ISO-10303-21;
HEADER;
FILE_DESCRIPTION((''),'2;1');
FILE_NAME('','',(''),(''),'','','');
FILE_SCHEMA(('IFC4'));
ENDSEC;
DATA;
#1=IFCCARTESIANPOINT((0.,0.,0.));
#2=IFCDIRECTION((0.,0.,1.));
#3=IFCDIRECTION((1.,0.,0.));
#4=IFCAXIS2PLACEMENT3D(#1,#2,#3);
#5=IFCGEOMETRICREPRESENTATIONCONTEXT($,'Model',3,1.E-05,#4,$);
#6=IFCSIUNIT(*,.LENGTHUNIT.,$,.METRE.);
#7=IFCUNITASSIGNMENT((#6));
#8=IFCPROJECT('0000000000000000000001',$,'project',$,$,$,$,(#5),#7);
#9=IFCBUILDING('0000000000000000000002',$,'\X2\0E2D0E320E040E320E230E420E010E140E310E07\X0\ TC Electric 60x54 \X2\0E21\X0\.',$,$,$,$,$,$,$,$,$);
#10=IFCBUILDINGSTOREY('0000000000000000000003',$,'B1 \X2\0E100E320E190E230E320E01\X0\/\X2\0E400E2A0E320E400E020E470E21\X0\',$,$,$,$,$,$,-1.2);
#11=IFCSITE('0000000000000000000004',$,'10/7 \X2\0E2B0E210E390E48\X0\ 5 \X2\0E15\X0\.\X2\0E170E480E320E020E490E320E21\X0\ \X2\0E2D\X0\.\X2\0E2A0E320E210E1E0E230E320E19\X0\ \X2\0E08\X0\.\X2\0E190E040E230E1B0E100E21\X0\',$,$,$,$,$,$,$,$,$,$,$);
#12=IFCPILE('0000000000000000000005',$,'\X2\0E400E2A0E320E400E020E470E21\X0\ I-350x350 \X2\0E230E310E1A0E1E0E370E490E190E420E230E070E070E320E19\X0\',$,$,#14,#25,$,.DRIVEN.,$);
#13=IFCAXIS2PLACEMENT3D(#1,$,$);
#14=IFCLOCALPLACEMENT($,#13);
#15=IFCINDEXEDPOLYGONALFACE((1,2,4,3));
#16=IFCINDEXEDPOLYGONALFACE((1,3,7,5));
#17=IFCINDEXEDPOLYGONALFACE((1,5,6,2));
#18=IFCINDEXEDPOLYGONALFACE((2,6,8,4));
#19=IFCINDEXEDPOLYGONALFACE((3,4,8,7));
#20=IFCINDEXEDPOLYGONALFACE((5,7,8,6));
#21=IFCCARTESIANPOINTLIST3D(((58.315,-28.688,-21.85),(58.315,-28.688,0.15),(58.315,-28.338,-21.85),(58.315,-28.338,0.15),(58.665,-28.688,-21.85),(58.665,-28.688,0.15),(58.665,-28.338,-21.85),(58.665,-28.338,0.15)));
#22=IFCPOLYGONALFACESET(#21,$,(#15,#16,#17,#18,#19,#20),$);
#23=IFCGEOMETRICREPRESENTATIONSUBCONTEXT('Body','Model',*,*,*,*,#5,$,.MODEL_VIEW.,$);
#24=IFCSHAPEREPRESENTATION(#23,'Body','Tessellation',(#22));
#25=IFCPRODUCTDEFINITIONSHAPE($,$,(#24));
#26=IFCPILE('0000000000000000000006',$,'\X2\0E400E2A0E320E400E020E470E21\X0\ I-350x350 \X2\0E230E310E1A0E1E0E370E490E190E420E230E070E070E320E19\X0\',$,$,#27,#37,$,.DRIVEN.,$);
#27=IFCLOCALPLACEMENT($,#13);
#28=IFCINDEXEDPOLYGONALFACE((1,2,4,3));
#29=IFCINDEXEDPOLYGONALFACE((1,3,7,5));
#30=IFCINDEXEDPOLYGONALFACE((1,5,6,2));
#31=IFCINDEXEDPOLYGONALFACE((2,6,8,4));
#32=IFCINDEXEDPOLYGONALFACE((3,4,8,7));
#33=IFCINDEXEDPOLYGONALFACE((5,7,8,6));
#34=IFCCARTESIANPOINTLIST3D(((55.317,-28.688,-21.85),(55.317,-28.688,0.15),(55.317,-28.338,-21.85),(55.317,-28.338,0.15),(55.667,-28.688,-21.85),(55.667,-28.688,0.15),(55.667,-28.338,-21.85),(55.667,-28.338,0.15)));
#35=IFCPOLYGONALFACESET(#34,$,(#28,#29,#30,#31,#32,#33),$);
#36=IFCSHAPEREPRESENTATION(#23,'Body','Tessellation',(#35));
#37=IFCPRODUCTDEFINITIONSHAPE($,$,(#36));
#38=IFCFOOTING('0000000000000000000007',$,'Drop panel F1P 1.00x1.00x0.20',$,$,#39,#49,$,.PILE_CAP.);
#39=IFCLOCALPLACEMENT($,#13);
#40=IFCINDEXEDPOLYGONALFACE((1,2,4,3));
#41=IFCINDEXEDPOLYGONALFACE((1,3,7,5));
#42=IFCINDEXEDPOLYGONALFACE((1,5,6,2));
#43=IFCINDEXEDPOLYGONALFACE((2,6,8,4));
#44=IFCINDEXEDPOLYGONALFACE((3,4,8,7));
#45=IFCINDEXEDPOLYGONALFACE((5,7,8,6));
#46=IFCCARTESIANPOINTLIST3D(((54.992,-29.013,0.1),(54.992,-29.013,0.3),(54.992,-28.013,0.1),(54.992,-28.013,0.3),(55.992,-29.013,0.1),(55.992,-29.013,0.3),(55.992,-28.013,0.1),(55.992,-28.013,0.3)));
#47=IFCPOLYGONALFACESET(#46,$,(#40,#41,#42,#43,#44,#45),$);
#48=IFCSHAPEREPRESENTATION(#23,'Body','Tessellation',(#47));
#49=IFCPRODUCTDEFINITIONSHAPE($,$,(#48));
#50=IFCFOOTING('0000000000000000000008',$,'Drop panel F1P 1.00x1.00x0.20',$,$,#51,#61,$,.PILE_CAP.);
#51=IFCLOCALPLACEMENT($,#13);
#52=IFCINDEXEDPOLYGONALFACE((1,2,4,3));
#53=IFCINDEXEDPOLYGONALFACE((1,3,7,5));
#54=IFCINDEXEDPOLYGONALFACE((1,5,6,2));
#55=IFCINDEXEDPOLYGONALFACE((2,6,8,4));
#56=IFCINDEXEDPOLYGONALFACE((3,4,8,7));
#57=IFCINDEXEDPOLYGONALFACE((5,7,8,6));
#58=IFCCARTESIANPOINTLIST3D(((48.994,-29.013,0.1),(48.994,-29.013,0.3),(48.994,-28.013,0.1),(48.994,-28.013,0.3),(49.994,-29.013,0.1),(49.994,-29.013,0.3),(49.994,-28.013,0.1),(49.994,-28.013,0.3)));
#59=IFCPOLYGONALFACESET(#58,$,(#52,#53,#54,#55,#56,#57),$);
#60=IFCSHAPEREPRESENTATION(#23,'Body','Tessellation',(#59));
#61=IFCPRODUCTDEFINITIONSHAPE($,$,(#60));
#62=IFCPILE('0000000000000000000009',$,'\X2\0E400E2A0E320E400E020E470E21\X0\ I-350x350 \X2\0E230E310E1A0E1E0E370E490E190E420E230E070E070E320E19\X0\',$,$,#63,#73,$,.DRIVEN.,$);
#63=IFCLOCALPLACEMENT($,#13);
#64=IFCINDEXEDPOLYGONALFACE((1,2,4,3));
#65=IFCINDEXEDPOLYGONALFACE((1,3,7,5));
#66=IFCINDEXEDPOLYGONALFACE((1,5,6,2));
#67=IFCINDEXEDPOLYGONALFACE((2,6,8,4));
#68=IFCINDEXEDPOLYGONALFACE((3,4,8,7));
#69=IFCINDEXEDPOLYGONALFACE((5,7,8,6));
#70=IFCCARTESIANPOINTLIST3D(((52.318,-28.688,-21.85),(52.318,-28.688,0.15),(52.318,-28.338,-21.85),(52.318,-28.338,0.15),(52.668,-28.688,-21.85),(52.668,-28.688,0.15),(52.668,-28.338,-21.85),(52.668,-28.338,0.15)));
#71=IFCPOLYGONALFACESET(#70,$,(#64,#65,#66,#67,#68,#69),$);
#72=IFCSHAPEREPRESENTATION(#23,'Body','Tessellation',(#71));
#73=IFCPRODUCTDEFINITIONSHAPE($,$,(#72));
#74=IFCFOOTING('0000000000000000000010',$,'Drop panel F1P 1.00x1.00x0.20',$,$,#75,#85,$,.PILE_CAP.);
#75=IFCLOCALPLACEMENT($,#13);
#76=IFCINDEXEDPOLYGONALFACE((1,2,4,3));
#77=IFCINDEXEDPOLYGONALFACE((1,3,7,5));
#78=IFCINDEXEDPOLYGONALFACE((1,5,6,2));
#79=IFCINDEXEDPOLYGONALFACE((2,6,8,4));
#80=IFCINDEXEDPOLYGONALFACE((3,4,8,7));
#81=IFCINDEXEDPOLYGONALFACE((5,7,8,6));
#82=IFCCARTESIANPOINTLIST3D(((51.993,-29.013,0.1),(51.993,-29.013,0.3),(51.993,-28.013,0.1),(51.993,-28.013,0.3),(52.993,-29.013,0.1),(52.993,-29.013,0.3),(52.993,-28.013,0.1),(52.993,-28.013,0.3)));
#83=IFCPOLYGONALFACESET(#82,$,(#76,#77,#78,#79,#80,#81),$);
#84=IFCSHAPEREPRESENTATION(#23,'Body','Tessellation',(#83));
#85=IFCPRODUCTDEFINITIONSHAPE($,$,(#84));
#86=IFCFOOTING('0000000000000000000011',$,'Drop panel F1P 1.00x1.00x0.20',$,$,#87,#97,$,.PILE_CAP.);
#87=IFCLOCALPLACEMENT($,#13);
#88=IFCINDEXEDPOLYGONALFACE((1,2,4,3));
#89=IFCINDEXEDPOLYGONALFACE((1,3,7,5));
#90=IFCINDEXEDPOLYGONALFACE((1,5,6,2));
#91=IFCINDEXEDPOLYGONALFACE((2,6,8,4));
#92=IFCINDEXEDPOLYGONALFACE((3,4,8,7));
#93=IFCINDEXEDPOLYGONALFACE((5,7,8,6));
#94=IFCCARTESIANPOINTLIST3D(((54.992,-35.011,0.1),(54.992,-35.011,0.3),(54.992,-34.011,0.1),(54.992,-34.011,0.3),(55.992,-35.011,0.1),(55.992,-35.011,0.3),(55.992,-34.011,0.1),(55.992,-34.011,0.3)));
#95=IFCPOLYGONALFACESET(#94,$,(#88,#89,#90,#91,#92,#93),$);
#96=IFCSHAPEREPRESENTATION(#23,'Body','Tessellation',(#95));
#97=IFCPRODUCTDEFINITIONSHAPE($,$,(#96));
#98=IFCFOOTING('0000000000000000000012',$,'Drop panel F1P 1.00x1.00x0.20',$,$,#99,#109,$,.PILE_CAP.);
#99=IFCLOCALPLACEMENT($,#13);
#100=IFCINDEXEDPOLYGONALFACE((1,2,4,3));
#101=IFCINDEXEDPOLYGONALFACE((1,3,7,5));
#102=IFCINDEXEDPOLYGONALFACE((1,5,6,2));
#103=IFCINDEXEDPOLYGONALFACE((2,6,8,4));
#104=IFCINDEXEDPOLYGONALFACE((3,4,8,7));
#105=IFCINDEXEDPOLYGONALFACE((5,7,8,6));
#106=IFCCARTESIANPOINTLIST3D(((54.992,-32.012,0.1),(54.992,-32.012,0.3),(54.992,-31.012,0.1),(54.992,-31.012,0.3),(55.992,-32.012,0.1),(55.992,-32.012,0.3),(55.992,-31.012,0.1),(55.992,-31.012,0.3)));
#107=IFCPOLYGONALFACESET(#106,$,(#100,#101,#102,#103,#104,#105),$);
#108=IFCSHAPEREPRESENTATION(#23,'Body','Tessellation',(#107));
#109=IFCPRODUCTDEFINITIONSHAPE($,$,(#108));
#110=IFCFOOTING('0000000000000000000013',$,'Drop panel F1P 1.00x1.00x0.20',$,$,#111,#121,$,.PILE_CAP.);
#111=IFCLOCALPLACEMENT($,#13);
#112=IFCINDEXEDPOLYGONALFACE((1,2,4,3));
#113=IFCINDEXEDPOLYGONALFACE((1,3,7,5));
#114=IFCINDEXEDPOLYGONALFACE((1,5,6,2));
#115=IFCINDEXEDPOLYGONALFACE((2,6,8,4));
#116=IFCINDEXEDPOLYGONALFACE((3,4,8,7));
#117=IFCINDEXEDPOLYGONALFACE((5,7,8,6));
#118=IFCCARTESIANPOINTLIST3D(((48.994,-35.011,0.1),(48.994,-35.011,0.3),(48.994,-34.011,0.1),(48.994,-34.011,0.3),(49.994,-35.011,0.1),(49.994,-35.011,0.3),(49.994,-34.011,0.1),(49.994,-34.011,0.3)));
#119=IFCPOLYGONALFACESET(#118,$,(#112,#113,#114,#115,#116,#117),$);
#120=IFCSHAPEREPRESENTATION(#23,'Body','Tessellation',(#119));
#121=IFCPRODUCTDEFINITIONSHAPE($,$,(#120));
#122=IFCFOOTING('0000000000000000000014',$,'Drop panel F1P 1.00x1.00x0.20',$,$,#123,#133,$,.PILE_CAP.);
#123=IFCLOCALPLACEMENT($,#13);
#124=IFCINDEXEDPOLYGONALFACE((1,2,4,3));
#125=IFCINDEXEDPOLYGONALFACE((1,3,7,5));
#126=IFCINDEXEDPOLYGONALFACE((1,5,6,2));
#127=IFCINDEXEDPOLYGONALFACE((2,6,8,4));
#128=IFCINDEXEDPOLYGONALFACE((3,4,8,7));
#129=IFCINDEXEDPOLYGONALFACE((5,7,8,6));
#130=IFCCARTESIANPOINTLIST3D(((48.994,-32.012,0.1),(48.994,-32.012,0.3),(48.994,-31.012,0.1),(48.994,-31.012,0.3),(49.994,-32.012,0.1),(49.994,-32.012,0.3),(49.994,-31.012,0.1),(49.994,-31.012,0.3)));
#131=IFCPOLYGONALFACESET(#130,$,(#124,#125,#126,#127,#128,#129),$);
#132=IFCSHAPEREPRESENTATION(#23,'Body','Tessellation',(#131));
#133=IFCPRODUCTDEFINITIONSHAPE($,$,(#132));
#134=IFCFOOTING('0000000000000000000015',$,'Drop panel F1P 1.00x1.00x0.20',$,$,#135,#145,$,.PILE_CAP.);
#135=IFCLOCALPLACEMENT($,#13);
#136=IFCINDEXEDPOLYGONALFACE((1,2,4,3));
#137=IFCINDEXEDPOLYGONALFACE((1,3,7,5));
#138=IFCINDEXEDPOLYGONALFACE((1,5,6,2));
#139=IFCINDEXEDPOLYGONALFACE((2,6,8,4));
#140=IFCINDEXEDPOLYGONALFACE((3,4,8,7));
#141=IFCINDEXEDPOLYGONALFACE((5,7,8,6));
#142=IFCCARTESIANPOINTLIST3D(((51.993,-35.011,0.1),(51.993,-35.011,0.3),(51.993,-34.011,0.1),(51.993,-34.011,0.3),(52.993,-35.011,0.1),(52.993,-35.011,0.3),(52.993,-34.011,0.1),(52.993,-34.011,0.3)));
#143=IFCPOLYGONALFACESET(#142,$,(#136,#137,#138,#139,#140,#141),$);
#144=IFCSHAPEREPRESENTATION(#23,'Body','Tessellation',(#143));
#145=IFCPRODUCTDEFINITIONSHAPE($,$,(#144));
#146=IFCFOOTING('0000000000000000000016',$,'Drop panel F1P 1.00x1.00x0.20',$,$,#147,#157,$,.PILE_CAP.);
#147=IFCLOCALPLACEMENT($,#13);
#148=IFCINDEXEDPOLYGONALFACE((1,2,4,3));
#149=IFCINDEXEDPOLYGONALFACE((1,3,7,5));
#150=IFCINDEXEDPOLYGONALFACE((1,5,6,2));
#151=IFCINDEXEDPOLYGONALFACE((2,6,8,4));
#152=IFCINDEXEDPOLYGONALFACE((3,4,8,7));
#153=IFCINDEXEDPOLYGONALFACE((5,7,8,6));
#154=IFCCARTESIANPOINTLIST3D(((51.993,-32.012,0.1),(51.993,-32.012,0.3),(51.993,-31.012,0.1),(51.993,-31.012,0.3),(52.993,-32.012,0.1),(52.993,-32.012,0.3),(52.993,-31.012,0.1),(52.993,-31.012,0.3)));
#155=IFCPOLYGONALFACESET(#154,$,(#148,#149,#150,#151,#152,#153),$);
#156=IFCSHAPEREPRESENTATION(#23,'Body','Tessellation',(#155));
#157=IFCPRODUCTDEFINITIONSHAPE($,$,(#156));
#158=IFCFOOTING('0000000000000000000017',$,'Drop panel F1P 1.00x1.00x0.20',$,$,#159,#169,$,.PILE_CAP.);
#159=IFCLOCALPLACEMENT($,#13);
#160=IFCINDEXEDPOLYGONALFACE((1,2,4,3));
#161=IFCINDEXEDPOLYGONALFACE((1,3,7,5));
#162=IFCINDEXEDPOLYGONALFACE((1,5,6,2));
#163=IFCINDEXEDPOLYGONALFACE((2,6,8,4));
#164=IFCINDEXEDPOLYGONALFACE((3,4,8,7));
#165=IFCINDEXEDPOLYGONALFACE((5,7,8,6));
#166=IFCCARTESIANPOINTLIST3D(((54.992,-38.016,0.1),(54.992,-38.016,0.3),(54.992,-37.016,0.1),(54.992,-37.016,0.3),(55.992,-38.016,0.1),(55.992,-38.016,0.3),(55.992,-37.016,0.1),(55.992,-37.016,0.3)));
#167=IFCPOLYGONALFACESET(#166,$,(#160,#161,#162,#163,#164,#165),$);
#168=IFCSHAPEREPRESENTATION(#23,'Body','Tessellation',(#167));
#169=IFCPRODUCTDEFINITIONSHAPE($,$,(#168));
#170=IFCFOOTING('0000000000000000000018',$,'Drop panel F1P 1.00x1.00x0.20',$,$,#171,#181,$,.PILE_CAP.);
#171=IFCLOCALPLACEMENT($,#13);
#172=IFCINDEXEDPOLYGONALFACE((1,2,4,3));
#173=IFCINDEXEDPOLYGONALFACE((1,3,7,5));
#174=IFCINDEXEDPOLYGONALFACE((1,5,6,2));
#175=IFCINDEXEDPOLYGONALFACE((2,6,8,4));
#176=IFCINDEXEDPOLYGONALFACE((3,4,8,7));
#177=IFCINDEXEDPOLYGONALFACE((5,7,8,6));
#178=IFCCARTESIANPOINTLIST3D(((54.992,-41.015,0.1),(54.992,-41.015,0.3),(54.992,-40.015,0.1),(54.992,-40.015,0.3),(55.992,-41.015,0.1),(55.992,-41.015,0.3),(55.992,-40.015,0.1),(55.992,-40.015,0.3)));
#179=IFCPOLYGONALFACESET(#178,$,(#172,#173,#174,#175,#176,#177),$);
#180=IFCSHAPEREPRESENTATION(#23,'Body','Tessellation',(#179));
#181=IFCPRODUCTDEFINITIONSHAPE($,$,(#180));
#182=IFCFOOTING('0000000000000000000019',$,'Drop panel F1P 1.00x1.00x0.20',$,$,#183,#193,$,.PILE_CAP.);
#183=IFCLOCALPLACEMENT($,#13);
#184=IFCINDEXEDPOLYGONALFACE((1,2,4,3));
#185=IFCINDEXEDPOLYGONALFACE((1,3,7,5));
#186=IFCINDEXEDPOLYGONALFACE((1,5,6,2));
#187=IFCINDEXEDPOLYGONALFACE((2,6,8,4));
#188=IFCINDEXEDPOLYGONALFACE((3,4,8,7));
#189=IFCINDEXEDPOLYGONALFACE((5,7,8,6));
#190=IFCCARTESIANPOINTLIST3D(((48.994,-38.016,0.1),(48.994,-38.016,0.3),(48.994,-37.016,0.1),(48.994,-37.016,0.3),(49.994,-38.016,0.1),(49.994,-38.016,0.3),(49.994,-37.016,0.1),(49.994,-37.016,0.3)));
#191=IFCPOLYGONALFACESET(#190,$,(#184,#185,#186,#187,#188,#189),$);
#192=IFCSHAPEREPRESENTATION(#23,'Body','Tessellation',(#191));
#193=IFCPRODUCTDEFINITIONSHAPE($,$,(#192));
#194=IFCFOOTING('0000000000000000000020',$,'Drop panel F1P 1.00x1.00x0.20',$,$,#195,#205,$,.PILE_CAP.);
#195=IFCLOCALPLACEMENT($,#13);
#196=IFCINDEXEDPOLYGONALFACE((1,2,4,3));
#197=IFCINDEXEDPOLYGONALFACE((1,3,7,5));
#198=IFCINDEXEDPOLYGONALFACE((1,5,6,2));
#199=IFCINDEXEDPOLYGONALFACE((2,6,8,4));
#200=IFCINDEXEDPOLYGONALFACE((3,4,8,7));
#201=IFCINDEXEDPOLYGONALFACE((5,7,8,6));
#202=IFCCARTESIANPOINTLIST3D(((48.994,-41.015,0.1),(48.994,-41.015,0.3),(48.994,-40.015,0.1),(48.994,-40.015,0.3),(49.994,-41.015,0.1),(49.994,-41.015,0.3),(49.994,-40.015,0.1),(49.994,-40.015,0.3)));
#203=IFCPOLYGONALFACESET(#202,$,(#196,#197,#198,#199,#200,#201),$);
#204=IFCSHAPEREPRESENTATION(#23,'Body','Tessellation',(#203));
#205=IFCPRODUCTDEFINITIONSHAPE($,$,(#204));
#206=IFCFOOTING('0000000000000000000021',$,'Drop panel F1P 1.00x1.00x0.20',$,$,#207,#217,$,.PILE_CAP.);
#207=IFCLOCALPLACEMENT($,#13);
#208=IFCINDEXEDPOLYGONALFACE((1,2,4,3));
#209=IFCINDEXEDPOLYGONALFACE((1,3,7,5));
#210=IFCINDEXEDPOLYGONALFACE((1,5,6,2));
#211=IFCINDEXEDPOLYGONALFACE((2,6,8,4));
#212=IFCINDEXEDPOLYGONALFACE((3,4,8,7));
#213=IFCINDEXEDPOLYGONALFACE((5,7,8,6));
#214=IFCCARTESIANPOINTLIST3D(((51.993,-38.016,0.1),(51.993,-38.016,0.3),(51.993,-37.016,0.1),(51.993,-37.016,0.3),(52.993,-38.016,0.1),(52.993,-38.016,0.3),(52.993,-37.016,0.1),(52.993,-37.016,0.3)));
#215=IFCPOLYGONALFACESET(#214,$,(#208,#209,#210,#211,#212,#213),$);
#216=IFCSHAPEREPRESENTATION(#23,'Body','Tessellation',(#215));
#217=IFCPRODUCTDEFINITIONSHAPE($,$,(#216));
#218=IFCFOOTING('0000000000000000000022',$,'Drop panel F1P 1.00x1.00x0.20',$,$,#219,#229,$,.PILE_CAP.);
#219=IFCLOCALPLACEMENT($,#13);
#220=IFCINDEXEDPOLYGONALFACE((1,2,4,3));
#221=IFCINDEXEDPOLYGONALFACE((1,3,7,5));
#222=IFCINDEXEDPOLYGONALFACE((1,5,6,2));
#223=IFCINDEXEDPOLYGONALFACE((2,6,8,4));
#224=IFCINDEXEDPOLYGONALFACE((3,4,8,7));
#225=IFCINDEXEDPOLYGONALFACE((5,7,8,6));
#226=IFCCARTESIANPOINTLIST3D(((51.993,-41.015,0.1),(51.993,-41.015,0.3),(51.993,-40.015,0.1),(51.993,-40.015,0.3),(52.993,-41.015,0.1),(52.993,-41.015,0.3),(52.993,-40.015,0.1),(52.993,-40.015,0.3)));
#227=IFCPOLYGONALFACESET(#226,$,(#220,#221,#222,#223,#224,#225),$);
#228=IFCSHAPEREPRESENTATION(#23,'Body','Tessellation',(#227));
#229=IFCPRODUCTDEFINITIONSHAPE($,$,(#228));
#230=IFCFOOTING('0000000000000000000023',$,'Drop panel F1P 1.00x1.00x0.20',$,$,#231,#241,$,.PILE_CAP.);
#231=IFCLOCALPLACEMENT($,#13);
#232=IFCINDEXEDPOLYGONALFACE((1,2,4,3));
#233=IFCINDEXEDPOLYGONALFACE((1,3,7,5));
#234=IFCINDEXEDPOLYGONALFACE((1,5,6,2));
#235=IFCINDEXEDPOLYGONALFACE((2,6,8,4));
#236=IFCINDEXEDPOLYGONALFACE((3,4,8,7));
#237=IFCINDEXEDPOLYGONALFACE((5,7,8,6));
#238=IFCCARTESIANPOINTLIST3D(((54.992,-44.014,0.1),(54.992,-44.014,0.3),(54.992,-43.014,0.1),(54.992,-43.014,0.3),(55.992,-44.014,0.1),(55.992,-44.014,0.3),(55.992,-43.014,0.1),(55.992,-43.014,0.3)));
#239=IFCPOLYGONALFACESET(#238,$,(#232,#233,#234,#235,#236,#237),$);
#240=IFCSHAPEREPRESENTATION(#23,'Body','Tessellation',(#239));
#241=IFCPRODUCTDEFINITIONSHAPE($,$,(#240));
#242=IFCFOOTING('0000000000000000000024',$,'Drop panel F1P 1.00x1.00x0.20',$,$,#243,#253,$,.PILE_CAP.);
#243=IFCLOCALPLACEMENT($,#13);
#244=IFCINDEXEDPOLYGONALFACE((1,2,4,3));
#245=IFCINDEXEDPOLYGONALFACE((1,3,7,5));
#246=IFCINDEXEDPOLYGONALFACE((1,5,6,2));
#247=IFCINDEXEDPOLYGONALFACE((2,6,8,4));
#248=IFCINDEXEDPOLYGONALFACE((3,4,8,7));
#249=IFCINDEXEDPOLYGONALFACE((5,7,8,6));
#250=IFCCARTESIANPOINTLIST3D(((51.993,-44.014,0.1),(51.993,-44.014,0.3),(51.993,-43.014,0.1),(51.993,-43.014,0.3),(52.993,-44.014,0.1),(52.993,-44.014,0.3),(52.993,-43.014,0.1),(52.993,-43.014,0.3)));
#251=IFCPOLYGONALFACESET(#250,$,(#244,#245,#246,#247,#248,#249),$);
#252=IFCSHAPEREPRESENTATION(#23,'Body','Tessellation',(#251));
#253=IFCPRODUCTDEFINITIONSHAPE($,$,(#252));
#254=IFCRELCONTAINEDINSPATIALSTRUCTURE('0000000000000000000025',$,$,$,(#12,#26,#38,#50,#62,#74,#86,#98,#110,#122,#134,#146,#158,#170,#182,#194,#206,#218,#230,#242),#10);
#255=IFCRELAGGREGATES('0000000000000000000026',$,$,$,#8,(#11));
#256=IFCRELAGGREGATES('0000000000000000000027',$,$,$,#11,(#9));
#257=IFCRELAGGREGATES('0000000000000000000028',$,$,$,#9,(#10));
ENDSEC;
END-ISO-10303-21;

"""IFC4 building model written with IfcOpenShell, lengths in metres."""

from ifc_helpers import new_model, si_unit, frame, origin, origin_with_axes, origin_2d, place, context, subcontext, project, spatial, rectangle, extrude, element, save


model = new_model("IFC4")

# Units and contexts
model_context = context("Model", 3, precision=1e-05, world=origin_with_axes())
body_context = subcontext(model_context, "Body", "Model", "MODEL_VIEW")
ifc_project = project(units=[si_unit("LENGTHUNIT", "METRE")], contexts=[model_context])

# Site, building, storey
site = spatial("IfcSite", under=ifc_project, Name="10/7 หมู่ 5 ต.ท่าข้าม อ.สามพราน จ.นครปฐม")
building = spatial("IfcBuilding", under=site, Name="อาคารโกดัง TC Electric 60x54 ม.")
storey = spatial("IfcBuildingStorey", under=building, Name="B1 ฐานราก/เสาเข็ม", Elevation=-1.2)

# Piles
for number, where, z_axis, x_axis, name in (
    (1, (58.49, -28.513, -21.85), (0.0, 0.0, 1.0), (1.0, 0.0, 0.0), "เสาเข็ม I-350x350 รับพื้นโรงงาน"),
    (2, (55.492, -28.513, -21.85), (0.0, 0.0, 1.0), (1.0, 0.0, 0.0), "เสาเข็ม I-350x350 รับพื้นโรงงาน"),
):
    element("IfcPile", number, at=place(None, frame(where, z_axis=z_axis, x_axis=x_axis)), inside=storey, Name=name, PredefinedType="DRIVEN", context=body_context, shape_type="SweptSolid", body=[
        extrude(rectangle(XDim=0.35, YDim=0.35, at=origin_2d()), origin(), (0.0, 0.0, 1.0), 22.0),
    ])

# Footings
for number, where, z_axis, x_axis, name in (
    (3, (55.492, -28.513, 0.1), (0.0, 0.0, 1.0), (1.0, 0.0, 0.0), "Drop panel F1P 1.00x1.00x0.20"),
    (4, (49.494, -28.513, 0.1), (0.0, 0.0, 1.0), (1.0, 0.0, 0.0), "Drop panel F1P 1.00x1.00x0.20"),
):
    element("IfcFooting", number, at=place(None, frame(where, z_axis=z_axis, x_axis=x_axis)), inside=storey, Name=name, PredefinedType="PILE_CAP", context=body_context, shape_type="SweptSolid", body=[
        extrude(rectangle(XDim=1.0, YDim=1.0, at=origin_2d()), origin(), (0.0, 0.0, 1.0), 0.2),
    ])

# Pile
pile_placement = place(None, frame((52.493, -28.513, -21.85), z_axis=(0.0, 0.0, 1.0), x_axis=(1.0, 0.0, 0.0)))
element("IfcPile", 5, at=pile_placement, inside=storey, Name="เสาเข็ม I-350x350 รับพื้นโรงงาน", PredefinedType="DRIVEN", context=body_context, shape_type="SweptSolid", body=[
    extrude(rectangle(XDim=0.35, YDim=0.35, at=origin_2d()), origin(), (0.0, 0.0, 1.0), 22.0),
])

# Footings
for number, where, z_axis, x_axis, name in (
    (6, (52.493, -28.513, 0.1), (0.0, 0.0, 1.0), (1.0, 0.0, 0.0), "Drop panel F1P 1.00x1.00x0.20"),
    (7, (55.492, -34.511, 0.1), (0.0, 0.0, 1.0), (1.0, 0.0, 0.0), "Drop panel F1P 1.00x1.00x0.20"),
    (8, (55.492, -31.512, 0.1), (0.0, 0.0, 1.0), (1.0, 0.0, 0.0), "Drop panel F1P 1.00x1.00x0.20"),
    (9, (49.494, -34.511, 0.1), (0.0, 0.0, 1.0), (1.0, 0.0, 0.0), "Drop panel F1P 1.00x1.00x0.20"),
    (10, (49.494, -31.512, 0.1), (0.0, 0.0, 1.0), (1.0, 0.0, 0.0), "Drop panel F1P 1.00x1.00x0.20"),
    (11, (52.493, -34.511, 0.1), (0.0, 0.0, 1.0), (1.0, 0.0, 0.0), "Drop panel F1P 1.00x1.00x0.20"),
    (12, (52.493, -31.512, 0.1), (0.0, 0.0, 1.0), (1.0, 0.0, 0.0), "Drop panel F1P 1.00x1.00x0.20"),
    (13, (55.492, -37.516, 0.1), (0.0, 0.0, 1.0), (1.0, 0.0, 0.0), "Drop panel F1P 1.00x1.00x0.20"),
    (14, (55.492, -40.515, 0.1), (0.0, 0.0, 1.0), (1.0, 0.0, 0.0), "Drop panel F1P 1.00x1.00x0.20"),
    (15, (49.494, -37.516, 0.1), (0.0, 0.0, 1.0), (1.0, 0.0, 0.0), "Drop panel F1P 1.00x1.00x0.20"),
    (16, (49.494, -40.515, 0.1), (0.0, 0.0, 1.0), (1.0, 0.0, 0.0), "Drop panel F1P 1.00x1.00x0.20"),
    (17, (52.493, -37.516, 0.1), (0.0, 0.0, 1.0), (1.0, 0.0, 0.0), "Drop panel F1P 1.00x1.00x0.20"),
    (18, (52.493, -40.515, 0.1), (0.0, 0.0, 1.0), (1.0, 0.0, 0.0), "Drop panel F1P 1.00x1.00x0.20"),
    (19, (55.492, -43.514, 0.1), (0.0, 0.0, 1.0), (1.0, 0.0, 0.0), "Drop panel F1P 1.00x1.00x0.20"),
    (20, (52.493, -43.514, 0.1), (0.0, 0.0, 1.0), (1.0, 0.0, 0.0), "Drop panel F1P 1.00x1.00x0.20"),
):
    element("IfcFooting", number, at=place(None, frame(where, z_axis=z_axis, x_axis=x_axis)), inside=storey, Name=name, PredefinedType="PILE_CAP", context=body_context, shape_type="SweptSolid", body=[
        extrude(rectangle(XDim=1.0, YDim=1.0, at=origin_2d()), origin(), (0.0, 0.0, 1.0), 0.2),
    ])

save(model, "model.ifc")
